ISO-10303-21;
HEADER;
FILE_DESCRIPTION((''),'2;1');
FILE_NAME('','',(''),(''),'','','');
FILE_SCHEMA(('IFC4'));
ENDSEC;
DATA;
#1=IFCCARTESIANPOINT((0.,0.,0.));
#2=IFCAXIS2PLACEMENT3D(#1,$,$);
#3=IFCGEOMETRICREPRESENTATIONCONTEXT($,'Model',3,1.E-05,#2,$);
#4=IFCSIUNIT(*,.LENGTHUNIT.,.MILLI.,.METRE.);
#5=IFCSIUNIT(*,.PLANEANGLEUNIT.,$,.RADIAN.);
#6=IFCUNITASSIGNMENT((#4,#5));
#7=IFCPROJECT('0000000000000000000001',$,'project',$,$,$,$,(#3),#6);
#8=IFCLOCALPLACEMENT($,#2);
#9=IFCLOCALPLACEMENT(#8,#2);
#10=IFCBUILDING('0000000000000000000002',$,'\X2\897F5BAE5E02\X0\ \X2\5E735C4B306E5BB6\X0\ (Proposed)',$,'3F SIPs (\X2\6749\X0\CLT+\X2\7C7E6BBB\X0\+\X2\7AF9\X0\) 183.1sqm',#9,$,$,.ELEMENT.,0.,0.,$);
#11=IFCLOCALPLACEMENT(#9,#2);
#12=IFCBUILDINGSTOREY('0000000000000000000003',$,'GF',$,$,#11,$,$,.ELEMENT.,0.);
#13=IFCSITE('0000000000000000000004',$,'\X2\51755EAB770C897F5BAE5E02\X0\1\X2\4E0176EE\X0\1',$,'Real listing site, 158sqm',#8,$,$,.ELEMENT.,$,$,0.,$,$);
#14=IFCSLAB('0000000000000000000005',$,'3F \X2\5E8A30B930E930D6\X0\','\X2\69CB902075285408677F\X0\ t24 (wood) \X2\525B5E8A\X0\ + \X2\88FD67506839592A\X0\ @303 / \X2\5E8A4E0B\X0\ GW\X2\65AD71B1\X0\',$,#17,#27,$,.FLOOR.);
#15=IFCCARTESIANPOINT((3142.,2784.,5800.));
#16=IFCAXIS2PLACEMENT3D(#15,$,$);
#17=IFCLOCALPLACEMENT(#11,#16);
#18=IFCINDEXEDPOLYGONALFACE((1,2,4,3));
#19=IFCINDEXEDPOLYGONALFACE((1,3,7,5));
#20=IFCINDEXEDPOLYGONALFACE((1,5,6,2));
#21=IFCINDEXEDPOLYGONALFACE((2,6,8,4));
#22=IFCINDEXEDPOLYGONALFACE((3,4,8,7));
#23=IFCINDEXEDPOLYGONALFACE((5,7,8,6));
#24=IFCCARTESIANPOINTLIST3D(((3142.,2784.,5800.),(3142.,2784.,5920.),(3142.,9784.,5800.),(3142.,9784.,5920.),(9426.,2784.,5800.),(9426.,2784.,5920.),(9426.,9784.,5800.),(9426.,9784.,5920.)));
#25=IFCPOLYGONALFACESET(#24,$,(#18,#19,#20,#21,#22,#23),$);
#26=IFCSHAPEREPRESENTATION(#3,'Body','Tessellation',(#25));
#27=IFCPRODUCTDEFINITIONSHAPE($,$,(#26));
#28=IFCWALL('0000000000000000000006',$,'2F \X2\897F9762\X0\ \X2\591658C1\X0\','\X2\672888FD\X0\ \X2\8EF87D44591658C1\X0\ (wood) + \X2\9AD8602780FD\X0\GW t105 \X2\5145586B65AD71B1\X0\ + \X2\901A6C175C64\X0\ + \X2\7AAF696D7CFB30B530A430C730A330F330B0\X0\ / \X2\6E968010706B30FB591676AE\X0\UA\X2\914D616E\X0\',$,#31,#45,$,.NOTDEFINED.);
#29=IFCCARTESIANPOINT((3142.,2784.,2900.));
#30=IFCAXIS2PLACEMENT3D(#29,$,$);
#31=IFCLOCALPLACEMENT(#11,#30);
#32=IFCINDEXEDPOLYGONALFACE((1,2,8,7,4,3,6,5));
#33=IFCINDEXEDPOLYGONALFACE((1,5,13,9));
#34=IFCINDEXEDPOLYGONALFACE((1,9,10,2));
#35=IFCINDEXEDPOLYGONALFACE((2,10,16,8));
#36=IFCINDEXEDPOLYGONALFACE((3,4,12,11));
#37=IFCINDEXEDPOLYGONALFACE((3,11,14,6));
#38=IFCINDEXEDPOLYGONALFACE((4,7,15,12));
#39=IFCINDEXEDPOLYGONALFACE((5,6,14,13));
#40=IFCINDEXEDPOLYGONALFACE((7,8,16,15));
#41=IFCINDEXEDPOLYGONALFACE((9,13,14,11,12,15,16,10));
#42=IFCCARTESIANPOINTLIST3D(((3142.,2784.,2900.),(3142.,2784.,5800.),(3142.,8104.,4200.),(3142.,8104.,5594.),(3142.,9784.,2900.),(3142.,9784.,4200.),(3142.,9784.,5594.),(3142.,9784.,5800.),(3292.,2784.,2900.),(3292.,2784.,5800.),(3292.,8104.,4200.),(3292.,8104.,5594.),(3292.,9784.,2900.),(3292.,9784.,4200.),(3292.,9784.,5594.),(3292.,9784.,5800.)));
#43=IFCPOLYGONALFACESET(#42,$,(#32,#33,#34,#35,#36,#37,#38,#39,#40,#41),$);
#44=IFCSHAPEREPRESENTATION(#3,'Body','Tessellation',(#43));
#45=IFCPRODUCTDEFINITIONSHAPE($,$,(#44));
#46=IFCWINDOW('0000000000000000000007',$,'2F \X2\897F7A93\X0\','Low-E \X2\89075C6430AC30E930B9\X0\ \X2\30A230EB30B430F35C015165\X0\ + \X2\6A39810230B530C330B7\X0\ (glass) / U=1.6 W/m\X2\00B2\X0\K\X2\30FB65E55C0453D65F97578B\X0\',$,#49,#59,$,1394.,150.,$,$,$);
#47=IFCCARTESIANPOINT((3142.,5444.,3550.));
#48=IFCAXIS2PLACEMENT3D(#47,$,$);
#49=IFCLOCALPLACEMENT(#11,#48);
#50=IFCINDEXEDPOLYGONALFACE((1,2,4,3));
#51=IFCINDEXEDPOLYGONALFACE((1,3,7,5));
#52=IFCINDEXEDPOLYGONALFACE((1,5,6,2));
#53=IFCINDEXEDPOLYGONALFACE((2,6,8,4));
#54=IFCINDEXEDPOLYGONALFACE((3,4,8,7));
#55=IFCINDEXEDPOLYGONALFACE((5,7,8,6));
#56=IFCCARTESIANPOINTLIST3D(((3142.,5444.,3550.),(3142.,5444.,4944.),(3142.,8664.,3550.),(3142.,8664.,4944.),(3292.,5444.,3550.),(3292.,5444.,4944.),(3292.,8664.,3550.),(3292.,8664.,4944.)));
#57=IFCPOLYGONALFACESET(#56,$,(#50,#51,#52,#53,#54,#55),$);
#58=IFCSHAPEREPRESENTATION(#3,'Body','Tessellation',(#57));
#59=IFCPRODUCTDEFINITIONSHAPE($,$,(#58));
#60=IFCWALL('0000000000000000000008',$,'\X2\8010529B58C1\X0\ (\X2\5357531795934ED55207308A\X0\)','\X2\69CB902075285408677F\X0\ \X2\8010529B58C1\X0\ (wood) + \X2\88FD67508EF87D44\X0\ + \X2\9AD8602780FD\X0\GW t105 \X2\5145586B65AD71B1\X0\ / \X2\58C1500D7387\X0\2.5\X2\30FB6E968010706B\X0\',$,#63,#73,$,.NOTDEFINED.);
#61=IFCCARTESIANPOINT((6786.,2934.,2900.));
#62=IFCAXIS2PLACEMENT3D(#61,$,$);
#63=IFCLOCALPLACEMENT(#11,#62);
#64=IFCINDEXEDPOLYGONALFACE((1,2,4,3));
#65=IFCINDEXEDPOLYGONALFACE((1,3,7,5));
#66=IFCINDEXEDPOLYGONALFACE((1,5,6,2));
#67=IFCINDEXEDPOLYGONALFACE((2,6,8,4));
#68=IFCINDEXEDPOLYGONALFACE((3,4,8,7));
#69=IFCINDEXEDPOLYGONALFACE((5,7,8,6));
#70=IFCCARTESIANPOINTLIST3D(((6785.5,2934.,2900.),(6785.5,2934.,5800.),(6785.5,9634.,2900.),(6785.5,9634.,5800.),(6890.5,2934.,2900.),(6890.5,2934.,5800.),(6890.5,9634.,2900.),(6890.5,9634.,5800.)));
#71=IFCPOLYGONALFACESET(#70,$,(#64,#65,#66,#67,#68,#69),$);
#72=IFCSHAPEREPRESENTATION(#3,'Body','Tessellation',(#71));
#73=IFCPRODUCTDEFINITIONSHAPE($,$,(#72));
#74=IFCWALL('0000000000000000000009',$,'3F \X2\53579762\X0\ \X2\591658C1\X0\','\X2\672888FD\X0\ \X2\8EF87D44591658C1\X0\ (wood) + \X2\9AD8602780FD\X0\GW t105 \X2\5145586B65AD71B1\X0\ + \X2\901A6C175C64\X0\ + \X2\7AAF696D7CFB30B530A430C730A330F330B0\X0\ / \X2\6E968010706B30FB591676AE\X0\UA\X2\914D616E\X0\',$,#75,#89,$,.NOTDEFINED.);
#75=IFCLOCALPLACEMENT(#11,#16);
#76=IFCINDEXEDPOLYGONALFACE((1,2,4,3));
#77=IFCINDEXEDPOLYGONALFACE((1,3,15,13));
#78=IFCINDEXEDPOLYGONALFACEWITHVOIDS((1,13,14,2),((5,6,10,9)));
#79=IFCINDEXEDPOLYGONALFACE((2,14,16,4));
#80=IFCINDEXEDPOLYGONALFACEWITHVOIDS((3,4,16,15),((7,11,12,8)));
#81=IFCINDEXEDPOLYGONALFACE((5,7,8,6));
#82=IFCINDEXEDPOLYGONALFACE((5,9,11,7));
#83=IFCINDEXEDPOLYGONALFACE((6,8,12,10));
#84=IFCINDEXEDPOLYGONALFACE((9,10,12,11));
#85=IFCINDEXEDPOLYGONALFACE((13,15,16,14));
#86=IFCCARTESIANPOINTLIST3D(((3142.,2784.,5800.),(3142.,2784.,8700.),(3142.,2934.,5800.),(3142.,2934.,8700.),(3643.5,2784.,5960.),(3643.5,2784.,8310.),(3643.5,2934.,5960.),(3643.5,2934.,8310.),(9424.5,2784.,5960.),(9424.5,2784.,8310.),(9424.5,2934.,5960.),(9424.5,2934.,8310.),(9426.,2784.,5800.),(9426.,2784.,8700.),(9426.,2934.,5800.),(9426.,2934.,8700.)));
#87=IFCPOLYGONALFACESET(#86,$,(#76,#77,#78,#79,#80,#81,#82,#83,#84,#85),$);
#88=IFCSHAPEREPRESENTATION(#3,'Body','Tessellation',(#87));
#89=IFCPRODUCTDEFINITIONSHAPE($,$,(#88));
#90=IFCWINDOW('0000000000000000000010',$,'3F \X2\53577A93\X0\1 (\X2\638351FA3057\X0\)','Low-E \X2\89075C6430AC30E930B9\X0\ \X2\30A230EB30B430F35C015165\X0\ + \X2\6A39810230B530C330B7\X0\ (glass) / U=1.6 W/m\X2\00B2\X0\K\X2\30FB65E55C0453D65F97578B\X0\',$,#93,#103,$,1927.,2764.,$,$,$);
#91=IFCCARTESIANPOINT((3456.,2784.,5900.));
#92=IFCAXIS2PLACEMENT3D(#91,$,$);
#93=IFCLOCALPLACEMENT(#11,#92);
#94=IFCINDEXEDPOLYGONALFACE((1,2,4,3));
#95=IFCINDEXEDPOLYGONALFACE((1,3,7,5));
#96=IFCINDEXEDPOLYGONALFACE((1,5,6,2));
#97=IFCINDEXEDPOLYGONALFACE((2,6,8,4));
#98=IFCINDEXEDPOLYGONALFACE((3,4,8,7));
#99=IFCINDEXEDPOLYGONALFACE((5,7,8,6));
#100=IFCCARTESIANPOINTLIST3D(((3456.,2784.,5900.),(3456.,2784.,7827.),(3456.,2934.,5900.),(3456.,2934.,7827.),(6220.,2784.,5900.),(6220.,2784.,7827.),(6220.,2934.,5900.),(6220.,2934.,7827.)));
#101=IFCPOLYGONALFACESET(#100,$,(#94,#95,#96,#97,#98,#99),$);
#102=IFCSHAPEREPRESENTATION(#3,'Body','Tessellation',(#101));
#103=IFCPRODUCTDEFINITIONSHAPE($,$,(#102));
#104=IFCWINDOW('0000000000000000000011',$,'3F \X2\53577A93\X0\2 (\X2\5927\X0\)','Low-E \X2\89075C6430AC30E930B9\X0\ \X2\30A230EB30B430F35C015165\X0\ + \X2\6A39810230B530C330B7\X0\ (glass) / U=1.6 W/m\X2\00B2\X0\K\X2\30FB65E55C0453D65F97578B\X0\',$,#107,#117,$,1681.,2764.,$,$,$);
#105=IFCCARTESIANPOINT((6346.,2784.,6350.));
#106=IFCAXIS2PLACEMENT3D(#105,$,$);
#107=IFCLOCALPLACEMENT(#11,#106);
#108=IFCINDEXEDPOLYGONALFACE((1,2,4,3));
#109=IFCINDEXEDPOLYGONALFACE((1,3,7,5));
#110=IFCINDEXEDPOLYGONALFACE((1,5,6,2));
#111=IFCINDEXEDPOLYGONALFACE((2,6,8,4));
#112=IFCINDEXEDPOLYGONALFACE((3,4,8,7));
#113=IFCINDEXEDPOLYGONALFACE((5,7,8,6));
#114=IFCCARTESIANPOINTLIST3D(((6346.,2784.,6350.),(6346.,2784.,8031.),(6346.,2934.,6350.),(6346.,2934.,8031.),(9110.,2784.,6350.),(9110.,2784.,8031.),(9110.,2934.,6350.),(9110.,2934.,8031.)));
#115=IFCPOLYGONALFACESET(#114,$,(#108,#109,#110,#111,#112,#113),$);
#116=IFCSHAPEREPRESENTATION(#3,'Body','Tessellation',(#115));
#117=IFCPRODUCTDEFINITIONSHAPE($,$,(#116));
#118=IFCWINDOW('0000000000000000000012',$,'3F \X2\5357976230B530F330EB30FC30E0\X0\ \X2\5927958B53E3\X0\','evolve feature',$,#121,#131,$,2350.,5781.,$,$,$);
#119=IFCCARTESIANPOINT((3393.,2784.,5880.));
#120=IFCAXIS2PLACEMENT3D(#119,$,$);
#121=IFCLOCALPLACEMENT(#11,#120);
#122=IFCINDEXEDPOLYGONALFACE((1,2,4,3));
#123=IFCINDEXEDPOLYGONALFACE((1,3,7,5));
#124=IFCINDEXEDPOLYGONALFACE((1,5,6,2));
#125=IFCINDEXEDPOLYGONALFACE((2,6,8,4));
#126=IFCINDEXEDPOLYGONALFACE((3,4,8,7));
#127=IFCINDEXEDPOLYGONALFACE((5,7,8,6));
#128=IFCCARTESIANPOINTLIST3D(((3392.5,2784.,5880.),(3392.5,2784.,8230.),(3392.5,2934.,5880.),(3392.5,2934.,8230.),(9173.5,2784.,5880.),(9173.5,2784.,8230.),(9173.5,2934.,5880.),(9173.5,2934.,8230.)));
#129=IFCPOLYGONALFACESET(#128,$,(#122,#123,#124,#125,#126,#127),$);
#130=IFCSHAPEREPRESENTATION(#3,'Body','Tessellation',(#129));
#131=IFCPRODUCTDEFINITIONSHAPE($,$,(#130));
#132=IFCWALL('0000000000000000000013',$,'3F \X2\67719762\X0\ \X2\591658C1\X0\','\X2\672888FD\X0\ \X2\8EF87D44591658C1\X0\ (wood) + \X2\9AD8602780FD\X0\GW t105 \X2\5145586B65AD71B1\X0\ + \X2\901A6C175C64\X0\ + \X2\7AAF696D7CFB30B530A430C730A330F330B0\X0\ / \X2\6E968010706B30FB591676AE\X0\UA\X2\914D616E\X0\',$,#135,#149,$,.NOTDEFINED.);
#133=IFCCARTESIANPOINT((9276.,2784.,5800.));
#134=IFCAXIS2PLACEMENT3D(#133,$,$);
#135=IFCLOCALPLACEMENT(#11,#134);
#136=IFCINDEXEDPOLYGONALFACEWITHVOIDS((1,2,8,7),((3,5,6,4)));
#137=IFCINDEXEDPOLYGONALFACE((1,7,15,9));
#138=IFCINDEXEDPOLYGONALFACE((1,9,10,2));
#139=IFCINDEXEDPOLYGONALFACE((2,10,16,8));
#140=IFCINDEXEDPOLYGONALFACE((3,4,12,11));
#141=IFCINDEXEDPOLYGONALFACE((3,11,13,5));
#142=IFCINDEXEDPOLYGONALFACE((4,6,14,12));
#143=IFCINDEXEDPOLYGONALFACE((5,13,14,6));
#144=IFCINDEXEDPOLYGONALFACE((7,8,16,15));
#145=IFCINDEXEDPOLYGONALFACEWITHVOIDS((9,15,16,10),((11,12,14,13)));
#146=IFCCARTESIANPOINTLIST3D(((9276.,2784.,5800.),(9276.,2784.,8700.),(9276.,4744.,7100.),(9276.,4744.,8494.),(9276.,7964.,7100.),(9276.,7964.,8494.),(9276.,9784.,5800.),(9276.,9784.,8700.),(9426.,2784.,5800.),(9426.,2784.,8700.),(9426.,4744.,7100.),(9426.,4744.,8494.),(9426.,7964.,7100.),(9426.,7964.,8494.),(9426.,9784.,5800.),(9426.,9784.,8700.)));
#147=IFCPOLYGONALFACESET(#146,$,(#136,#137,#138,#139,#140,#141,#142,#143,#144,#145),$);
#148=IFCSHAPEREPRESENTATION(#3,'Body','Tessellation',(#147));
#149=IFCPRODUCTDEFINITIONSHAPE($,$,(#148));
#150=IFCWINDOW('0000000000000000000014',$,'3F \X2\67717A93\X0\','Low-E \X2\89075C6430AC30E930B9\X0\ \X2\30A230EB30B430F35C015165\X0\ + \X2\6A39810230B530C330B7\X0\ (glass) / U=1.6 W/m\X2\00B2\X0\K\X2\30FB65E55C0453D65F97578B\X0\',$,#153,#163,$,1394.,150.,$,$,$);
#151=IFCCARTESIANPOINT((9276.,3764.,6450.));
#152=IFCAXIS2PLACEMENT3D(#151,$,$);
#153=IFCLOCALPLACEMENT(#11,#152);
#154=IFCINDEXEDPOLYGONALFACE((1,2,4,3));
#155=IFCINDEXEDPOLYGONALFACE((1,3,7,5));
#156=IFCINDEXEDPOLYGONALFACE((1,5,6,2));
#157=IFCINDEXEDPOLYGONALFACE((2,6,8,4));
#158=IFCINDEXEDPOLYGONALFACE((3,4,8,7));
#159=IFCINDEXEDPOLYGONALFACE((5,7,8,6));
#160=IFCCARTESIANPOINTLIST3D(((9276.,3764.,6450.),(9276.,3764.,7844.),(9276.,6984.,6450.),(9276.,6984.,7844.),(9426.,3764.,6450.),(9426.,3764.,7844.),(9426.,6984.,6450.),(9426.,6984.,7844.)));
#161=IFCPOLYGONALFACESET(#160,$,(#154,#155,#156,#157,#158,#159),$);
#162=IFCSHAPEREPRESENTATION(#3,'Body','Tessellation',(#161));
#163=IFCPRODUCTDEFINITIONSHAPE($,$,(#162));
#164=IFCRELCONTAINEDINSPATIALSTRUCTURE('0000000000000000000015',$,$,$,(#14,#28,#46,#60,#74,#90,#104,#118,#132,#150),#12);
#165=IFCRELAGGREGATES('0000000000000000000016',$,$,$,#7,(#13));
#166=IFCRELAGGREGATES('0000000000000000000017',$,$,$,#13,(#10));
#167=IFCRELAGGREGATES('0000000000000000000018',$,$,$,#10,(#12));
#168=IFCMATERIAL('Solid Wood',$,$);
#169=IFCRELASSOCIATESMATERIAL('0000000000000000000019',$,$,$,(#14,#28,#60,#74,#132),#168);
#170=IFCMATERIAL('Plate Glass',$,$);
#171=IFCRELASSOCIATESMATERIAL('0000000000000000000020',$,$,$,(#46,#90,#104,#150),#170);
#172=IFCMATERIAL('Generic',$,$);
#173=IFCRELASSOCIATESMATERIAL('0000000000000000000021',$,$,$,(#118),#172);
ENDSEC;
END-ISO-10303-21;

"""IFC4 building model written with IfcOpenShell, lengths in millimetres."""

from ifc_helpers import new_model, si_unit, frame, frame_2d, origin, place, context, project, spatial, rectangle, extrude, material, element, fill, save


model = new_model("IFC4")

# Units and contexts
model_context = context("Model", 3, precision=1e-05, world=origin())
ifc_project = project(units=[si_unit("LENGTHUNIT", "METRE", prefix="MILLI"), si_unit("PLANEANGLEUNIT", "RADIAN")], contexts=[model_context])

# Site, building, storey
site_placement = place(None, origin())
site = spatial("IfcSite", under=ifc_project, at=site_placement, Name="兵庫県西宮市1丁目1", ObjectType="Real listing site, 158sqm", CompositionType="ELEMENT", RefElevation=0.0)
building_placement = place(site_placement, origin())
building = spatial("IfcBuilding", under=site, at=building_placement, Name="西宮市 平屋の家 (Proposed)", ObjectType="3F SIPs (杉CLT+籾殻+竹) 183.1sqm", CompositionType="ELEMENT", ElevationOfRefHeight=0.0, ElevationOfTerrain=0.0)
storey_placement = place(building_placement, origin())
storey = spatial("IfcBuildingStorey", under=building, at=storey_placement, Name="GF", CompositionType="ELEMENT", Elevation=0.0)

# Slab
ifc_material_1 = material(Name="Solid Wood")
slab_placement = place(storey_placement, frame((3142.0, 2784.0, 5800.0)))
element("IfcSlab", 1, at=slab_placement, inside=storey, material=ifc_material_1, Name="3F 床スラブ", Description="構造用合板 t24 (wood) 剛床 + 製材根太 @303 / 床下 GW断熱", PredefinedType="FLOOR", context=model_context, shape_type="SweptSolid", body=[
    extrude(rectangle(XDim=6284.0, YDim=7000.0, at=frame_2d((3142.0, 3500.0))), frame((3142.0, 2784.0, 5800.0)), (0.0, 0.0, 1.0), 120.0),
])

# Wall, opening, window
wall_1_placement = place(storey_placement, frame((3142.0, 2784.0, 2900.0)))
wall_1 = element("IfcWall", 2, at=wall_1_placement, inside=storey, material=ifc_material_1, Name="2F 西面 外壁", Description="木製 軸組外壁 (wood) + 高性能GW t105 充填断熱 + 通気層 + 窯業系サイディング / 準耐火・外皮UA配慮", PredefinedType="NOTDEFINED", context=model_context, shape_type="SweptSolid", body=[
    extrude(rectangle(XDim=150.0, YDim=7000.0, at=frame_2d((75.0, 3500.0))), frame((3142.0, 2784.0, 2900.0)), (0.0, 0.0, 1.0), 2900.0),
])
opening_1_placement = place(storey_placement, frame((3142.0, 5444.0, 3550.0)))
opening_1 = element("IfcOpeningElement", 3, at=opening_1_placement, cuts=wall_1, PredefinedType="NOTDEFINED", context=model_context, shape_type="SweptSolid", body=[
    extrude(rectangle(XDim=150.0, YDim=3220.0, at=frame_2d((75.0, 1610.0))), frame((3142.0, 5444.0, 3550.0)), (0.0, 0.0, 1.0), 1394.0),
])
ifc_material_2 = material(Name="Plate Glass")
window_1_placement = place(storey_placement, frame((3142.0, 5444.0, 3550.0)))
window_1 = element("IfcWindow", 4, at=window_1_placement, inside=storey, material=ifc_material_2, Name="2F 西窓", Description="Low-E 複層ガラス アルゴン封入 + 樹脂サッシ (glass) / U=1.6 W/m²K・日射取得型", OverallHeight=1394.0, OverallWidth=150.0, context=model_context, shape_type="SweptSolid", body=[
    extrude(rectangle(XDim=150.0, YDim=3220.0, at=frame_2d((75.0, 1610.0))), frame((3142.0, 5444.0, 3550.0)), (0.0, 0.0, 1.0), 1394.0),
])
fill(opening_1, window_1)

# Wall
wall_2_placement = place(storey_placement, frame((6786.0, 2934.0, 2900.0)))
element("IfcWall", 5, at=wall_2_placement, inside=storey, material=ifc_material_1, Name="耐力壁 (南北間仕切り)", Description="構造用合板 耐力壁 (wood) + 製材軸組 + 高性能GW t105 充填断熱 / 壁倍率2.5・準耐火", PredefinedType="NOTDEFINED", context=model_context, shape_type="SweptSolid", body=[
    extrude(rectangle(XDim=105.0, YDim=6700.0, at=frame_2d((52.0, 3350.0))), frame((6786.0, 2934.0, 2900.0)), (0.0, 0.0, 1.0), 2900.0),
])

# Wall, openings, windows
wall_3_placement = place(storey_placement, frame((3142.0, 2784.0, 5800.0)))
wall_3 = element("IfcWall", 6, at=wall_3_placement, inside=storey, material=ifc_material_1, Name="3F 南面 外壁", Description="木製 軸組外壁 (wood) + 高性能GW t105 充填断熱 + 通気層 + 窯業系サイディング / 準耐火・外皮UA配慮", PredefinedType="NOTDEFINED", context=model_context, shape_type="SweptSolid", body=[
    extrude(rectangle(XDim=6284.0, YDim=150.0, at=frame_2d((3142.0, 75.0))), frame((3142.0, 2784.0, 5800.0)), (0.0, 0.0, 1.0), 2900.0),
])
opening_2_placement = place(storey_placement, frame((3456.0, 2784.0, 5900.0)))
opening_2 = element("IfcOpeningElement", 7, at=opening_2_placement, cuts=wall_3, PredefinedType="NOTDEFINED", context=model_context, shape_type="SweptSolid", body=[
    extrude(rectangle(XDim=2764.0, YDim=150.0, at=frame_2d((1382.0, 75.0))), frame((3456.0, 2784.0, 5900.0)), (0.0, 0.0, 1.0), 1927.0),
])
opening_3_placement = place(storey_placement, frame((6346.0, 2784.0, 6350.0)))
opening_3 = element("IfcOpeningElement", 8, at=opening_3_placement, cuts=wall_3, PredefinedType="NOTDEFINED", context=model_context, shape_type="SweptSolid", body=[
    extrude(rectangle(XDim=2764.0, YDim=150.0, at=frame_2d((1382.0, 75.0))), frame((6346.0, 2784.0, 6350.0)), (0.0, 0.0, 1.0), 1681.0),
])
opening_4_placement = place(storey_placement, frame((3393.0, 2784.0, 5880.0)))
opening_4 = element("IfcOpeningElement", 9, at=opening_4_placement, cuts=wall_3, PredefinedType="NOTDEFINED", context=model_context, shape_type="SweptSolid", body=[
    extrude(rectangle(XDim=5781.0, YDim=150.0, at=frame_2d((2890.0, 75.0))), frame((3393.0, 2784.0, 5880.0)), (0.0, 0.0, 1.0), 2350.0),
])
window_2_placement = place(storey_placement, frame((3456.0, 2784.0, 5900.0)))
window_2 = element("IfcWindow", 10, at=window_2_placement, inside=storey, material=ifc_material_2, Name="3F 南窓1 (掃出し)", Description="Low-E 複層ガラス アルゴン封入 + 樹脂サッシ (glass) / U=1.6 W/m²K・日射取得型", OverallHeight=1927.0, OverallWidth=2764.0, context=model_context, shape_type="SweptSolid", body=[
    extrude(rectangle(XDim=2764.0, YDim=150.0, at=frame_2d((1382.0, 75.0))), frame((3456.0, 2784.0, 5900.0)), (0.0, 0.0, 1.0), 1927.0),
])
fill(opening_2, window_2)
window_3_placement = place(storey_placement, frame((6346.0, 2784.0, 6350.0)))
window_3 = element("IfcWindow", 11, at=window_3_placement, inside=storey, material=ifc_material_2, Name="3F 南窓2 (大)", Description="Low-E 複層ガラス アルゴン封入 + 樹脂サッシ (glass) / U=1.6 W/m²K・日射取得型", OverallHeight=1681.0, OverallWidth=2764.0, context=model_context, shape_type="SweptSolid", body=[
    extrude(rectangle(XDim=2764.0, YDim=150.0, at=frame_2d((1382.0, 75.0))), frame((6346.0, 2784.0, 6350.0)), (0.0, 0.0, 1.0), 1681.0),
])
fill(opening_3, window_3)
ifc_material_3 = material(Name="Generic")
window_4_placement = place(storey_placement, frame((3393.0, 2784.0, 5880.0)))
window_4 = element("IfcWindow", 12, at=window_4_placement, inside=storey, material=ifc_material_3, Name="3F 南面サンルーム 大開口", Description="evolve feature", OverallHeight=2350.0, OverallWidth=5781.0, context=model_context, shape_type="SweptSolid", body=[
    extrude(rectangle(XDim=5781.0, YDim=150.0, at=frame_2d((2890.0, 75.0))), frame((3393.0, 2784.0, 5880.0)), (0.0, 0.0, 1.0), 2350.0),
])
fill(opening_4, window_4)

# Wall, opening, window
wall_4_placement = place(storey_placement, frame((9276.0, 2784.0, 5800.0)))
wall_4 = element("IfcWall", 13, at=wall_4_placement, inside=storey, material=ifc_material_1, Name="3F 東面 外壁", Description="木製 軸組外壁 (wood) + 高性能GW t105 充填断熱 + 通気層 + 窯業系サイディング / 準耐火・外皮UA配慮", PredefinedType="NOTDEFINED", context=model_context, shape_type="SweptSolid", body=[
    extrude(rectangle(XDim=150.0, YDim=7000.0, at=frame_2d((75.0, 3500.0))), frame((9276.0, 2784.0, 5800.0)), (0.0, 0.0, 1.0), 2900.0),
])
opening_5_placement = place(storey_placement, frame((9276.0, 3764.0, 6450.0)))
opening_5 = element("IfcOpeningElement", 14, at=opening_5_placement, cuts=wall_4, PredefinedType="NOTDEFINED", context=model_context, shape_type="SweptSolid", body=[
    extrude(rectangle(XDim=150.0, YDim=3220.0, at=frame_2d((75.0, 1610.0))), frame((9276.0, 3764.0, 6450.0)), (0.0, 0.0, 1.0), 1394.0),
])
window_5_placement = place(storey_placement, frame((9276.0, 3764.0, 6450.0)))
window_5 = element("IfcWindow", 15, at=window_5_placement, inside=storey, material=ifc_material_2, Name="3F 東窓", Description="Low-E 複層ガラス アルゴン封入 + 樹脂サッシ (glass) / U=1.6 W/m²K・日射取得型", OverallHeight=1394.0, OverallWidth=150.0, context=model_context, shape_type="SweptSolid", body=[
    extrude(rectangle(XDim=150.0, YDim=3220.0, at=frame_2d((75.0, 1610.0))), frame((9276.0, 3764.0, 6450.0)), (0.0, 0.0, 1.0), 1394.0),
])
fill(opening_5, window_5)

save(model, "model.ifc")
